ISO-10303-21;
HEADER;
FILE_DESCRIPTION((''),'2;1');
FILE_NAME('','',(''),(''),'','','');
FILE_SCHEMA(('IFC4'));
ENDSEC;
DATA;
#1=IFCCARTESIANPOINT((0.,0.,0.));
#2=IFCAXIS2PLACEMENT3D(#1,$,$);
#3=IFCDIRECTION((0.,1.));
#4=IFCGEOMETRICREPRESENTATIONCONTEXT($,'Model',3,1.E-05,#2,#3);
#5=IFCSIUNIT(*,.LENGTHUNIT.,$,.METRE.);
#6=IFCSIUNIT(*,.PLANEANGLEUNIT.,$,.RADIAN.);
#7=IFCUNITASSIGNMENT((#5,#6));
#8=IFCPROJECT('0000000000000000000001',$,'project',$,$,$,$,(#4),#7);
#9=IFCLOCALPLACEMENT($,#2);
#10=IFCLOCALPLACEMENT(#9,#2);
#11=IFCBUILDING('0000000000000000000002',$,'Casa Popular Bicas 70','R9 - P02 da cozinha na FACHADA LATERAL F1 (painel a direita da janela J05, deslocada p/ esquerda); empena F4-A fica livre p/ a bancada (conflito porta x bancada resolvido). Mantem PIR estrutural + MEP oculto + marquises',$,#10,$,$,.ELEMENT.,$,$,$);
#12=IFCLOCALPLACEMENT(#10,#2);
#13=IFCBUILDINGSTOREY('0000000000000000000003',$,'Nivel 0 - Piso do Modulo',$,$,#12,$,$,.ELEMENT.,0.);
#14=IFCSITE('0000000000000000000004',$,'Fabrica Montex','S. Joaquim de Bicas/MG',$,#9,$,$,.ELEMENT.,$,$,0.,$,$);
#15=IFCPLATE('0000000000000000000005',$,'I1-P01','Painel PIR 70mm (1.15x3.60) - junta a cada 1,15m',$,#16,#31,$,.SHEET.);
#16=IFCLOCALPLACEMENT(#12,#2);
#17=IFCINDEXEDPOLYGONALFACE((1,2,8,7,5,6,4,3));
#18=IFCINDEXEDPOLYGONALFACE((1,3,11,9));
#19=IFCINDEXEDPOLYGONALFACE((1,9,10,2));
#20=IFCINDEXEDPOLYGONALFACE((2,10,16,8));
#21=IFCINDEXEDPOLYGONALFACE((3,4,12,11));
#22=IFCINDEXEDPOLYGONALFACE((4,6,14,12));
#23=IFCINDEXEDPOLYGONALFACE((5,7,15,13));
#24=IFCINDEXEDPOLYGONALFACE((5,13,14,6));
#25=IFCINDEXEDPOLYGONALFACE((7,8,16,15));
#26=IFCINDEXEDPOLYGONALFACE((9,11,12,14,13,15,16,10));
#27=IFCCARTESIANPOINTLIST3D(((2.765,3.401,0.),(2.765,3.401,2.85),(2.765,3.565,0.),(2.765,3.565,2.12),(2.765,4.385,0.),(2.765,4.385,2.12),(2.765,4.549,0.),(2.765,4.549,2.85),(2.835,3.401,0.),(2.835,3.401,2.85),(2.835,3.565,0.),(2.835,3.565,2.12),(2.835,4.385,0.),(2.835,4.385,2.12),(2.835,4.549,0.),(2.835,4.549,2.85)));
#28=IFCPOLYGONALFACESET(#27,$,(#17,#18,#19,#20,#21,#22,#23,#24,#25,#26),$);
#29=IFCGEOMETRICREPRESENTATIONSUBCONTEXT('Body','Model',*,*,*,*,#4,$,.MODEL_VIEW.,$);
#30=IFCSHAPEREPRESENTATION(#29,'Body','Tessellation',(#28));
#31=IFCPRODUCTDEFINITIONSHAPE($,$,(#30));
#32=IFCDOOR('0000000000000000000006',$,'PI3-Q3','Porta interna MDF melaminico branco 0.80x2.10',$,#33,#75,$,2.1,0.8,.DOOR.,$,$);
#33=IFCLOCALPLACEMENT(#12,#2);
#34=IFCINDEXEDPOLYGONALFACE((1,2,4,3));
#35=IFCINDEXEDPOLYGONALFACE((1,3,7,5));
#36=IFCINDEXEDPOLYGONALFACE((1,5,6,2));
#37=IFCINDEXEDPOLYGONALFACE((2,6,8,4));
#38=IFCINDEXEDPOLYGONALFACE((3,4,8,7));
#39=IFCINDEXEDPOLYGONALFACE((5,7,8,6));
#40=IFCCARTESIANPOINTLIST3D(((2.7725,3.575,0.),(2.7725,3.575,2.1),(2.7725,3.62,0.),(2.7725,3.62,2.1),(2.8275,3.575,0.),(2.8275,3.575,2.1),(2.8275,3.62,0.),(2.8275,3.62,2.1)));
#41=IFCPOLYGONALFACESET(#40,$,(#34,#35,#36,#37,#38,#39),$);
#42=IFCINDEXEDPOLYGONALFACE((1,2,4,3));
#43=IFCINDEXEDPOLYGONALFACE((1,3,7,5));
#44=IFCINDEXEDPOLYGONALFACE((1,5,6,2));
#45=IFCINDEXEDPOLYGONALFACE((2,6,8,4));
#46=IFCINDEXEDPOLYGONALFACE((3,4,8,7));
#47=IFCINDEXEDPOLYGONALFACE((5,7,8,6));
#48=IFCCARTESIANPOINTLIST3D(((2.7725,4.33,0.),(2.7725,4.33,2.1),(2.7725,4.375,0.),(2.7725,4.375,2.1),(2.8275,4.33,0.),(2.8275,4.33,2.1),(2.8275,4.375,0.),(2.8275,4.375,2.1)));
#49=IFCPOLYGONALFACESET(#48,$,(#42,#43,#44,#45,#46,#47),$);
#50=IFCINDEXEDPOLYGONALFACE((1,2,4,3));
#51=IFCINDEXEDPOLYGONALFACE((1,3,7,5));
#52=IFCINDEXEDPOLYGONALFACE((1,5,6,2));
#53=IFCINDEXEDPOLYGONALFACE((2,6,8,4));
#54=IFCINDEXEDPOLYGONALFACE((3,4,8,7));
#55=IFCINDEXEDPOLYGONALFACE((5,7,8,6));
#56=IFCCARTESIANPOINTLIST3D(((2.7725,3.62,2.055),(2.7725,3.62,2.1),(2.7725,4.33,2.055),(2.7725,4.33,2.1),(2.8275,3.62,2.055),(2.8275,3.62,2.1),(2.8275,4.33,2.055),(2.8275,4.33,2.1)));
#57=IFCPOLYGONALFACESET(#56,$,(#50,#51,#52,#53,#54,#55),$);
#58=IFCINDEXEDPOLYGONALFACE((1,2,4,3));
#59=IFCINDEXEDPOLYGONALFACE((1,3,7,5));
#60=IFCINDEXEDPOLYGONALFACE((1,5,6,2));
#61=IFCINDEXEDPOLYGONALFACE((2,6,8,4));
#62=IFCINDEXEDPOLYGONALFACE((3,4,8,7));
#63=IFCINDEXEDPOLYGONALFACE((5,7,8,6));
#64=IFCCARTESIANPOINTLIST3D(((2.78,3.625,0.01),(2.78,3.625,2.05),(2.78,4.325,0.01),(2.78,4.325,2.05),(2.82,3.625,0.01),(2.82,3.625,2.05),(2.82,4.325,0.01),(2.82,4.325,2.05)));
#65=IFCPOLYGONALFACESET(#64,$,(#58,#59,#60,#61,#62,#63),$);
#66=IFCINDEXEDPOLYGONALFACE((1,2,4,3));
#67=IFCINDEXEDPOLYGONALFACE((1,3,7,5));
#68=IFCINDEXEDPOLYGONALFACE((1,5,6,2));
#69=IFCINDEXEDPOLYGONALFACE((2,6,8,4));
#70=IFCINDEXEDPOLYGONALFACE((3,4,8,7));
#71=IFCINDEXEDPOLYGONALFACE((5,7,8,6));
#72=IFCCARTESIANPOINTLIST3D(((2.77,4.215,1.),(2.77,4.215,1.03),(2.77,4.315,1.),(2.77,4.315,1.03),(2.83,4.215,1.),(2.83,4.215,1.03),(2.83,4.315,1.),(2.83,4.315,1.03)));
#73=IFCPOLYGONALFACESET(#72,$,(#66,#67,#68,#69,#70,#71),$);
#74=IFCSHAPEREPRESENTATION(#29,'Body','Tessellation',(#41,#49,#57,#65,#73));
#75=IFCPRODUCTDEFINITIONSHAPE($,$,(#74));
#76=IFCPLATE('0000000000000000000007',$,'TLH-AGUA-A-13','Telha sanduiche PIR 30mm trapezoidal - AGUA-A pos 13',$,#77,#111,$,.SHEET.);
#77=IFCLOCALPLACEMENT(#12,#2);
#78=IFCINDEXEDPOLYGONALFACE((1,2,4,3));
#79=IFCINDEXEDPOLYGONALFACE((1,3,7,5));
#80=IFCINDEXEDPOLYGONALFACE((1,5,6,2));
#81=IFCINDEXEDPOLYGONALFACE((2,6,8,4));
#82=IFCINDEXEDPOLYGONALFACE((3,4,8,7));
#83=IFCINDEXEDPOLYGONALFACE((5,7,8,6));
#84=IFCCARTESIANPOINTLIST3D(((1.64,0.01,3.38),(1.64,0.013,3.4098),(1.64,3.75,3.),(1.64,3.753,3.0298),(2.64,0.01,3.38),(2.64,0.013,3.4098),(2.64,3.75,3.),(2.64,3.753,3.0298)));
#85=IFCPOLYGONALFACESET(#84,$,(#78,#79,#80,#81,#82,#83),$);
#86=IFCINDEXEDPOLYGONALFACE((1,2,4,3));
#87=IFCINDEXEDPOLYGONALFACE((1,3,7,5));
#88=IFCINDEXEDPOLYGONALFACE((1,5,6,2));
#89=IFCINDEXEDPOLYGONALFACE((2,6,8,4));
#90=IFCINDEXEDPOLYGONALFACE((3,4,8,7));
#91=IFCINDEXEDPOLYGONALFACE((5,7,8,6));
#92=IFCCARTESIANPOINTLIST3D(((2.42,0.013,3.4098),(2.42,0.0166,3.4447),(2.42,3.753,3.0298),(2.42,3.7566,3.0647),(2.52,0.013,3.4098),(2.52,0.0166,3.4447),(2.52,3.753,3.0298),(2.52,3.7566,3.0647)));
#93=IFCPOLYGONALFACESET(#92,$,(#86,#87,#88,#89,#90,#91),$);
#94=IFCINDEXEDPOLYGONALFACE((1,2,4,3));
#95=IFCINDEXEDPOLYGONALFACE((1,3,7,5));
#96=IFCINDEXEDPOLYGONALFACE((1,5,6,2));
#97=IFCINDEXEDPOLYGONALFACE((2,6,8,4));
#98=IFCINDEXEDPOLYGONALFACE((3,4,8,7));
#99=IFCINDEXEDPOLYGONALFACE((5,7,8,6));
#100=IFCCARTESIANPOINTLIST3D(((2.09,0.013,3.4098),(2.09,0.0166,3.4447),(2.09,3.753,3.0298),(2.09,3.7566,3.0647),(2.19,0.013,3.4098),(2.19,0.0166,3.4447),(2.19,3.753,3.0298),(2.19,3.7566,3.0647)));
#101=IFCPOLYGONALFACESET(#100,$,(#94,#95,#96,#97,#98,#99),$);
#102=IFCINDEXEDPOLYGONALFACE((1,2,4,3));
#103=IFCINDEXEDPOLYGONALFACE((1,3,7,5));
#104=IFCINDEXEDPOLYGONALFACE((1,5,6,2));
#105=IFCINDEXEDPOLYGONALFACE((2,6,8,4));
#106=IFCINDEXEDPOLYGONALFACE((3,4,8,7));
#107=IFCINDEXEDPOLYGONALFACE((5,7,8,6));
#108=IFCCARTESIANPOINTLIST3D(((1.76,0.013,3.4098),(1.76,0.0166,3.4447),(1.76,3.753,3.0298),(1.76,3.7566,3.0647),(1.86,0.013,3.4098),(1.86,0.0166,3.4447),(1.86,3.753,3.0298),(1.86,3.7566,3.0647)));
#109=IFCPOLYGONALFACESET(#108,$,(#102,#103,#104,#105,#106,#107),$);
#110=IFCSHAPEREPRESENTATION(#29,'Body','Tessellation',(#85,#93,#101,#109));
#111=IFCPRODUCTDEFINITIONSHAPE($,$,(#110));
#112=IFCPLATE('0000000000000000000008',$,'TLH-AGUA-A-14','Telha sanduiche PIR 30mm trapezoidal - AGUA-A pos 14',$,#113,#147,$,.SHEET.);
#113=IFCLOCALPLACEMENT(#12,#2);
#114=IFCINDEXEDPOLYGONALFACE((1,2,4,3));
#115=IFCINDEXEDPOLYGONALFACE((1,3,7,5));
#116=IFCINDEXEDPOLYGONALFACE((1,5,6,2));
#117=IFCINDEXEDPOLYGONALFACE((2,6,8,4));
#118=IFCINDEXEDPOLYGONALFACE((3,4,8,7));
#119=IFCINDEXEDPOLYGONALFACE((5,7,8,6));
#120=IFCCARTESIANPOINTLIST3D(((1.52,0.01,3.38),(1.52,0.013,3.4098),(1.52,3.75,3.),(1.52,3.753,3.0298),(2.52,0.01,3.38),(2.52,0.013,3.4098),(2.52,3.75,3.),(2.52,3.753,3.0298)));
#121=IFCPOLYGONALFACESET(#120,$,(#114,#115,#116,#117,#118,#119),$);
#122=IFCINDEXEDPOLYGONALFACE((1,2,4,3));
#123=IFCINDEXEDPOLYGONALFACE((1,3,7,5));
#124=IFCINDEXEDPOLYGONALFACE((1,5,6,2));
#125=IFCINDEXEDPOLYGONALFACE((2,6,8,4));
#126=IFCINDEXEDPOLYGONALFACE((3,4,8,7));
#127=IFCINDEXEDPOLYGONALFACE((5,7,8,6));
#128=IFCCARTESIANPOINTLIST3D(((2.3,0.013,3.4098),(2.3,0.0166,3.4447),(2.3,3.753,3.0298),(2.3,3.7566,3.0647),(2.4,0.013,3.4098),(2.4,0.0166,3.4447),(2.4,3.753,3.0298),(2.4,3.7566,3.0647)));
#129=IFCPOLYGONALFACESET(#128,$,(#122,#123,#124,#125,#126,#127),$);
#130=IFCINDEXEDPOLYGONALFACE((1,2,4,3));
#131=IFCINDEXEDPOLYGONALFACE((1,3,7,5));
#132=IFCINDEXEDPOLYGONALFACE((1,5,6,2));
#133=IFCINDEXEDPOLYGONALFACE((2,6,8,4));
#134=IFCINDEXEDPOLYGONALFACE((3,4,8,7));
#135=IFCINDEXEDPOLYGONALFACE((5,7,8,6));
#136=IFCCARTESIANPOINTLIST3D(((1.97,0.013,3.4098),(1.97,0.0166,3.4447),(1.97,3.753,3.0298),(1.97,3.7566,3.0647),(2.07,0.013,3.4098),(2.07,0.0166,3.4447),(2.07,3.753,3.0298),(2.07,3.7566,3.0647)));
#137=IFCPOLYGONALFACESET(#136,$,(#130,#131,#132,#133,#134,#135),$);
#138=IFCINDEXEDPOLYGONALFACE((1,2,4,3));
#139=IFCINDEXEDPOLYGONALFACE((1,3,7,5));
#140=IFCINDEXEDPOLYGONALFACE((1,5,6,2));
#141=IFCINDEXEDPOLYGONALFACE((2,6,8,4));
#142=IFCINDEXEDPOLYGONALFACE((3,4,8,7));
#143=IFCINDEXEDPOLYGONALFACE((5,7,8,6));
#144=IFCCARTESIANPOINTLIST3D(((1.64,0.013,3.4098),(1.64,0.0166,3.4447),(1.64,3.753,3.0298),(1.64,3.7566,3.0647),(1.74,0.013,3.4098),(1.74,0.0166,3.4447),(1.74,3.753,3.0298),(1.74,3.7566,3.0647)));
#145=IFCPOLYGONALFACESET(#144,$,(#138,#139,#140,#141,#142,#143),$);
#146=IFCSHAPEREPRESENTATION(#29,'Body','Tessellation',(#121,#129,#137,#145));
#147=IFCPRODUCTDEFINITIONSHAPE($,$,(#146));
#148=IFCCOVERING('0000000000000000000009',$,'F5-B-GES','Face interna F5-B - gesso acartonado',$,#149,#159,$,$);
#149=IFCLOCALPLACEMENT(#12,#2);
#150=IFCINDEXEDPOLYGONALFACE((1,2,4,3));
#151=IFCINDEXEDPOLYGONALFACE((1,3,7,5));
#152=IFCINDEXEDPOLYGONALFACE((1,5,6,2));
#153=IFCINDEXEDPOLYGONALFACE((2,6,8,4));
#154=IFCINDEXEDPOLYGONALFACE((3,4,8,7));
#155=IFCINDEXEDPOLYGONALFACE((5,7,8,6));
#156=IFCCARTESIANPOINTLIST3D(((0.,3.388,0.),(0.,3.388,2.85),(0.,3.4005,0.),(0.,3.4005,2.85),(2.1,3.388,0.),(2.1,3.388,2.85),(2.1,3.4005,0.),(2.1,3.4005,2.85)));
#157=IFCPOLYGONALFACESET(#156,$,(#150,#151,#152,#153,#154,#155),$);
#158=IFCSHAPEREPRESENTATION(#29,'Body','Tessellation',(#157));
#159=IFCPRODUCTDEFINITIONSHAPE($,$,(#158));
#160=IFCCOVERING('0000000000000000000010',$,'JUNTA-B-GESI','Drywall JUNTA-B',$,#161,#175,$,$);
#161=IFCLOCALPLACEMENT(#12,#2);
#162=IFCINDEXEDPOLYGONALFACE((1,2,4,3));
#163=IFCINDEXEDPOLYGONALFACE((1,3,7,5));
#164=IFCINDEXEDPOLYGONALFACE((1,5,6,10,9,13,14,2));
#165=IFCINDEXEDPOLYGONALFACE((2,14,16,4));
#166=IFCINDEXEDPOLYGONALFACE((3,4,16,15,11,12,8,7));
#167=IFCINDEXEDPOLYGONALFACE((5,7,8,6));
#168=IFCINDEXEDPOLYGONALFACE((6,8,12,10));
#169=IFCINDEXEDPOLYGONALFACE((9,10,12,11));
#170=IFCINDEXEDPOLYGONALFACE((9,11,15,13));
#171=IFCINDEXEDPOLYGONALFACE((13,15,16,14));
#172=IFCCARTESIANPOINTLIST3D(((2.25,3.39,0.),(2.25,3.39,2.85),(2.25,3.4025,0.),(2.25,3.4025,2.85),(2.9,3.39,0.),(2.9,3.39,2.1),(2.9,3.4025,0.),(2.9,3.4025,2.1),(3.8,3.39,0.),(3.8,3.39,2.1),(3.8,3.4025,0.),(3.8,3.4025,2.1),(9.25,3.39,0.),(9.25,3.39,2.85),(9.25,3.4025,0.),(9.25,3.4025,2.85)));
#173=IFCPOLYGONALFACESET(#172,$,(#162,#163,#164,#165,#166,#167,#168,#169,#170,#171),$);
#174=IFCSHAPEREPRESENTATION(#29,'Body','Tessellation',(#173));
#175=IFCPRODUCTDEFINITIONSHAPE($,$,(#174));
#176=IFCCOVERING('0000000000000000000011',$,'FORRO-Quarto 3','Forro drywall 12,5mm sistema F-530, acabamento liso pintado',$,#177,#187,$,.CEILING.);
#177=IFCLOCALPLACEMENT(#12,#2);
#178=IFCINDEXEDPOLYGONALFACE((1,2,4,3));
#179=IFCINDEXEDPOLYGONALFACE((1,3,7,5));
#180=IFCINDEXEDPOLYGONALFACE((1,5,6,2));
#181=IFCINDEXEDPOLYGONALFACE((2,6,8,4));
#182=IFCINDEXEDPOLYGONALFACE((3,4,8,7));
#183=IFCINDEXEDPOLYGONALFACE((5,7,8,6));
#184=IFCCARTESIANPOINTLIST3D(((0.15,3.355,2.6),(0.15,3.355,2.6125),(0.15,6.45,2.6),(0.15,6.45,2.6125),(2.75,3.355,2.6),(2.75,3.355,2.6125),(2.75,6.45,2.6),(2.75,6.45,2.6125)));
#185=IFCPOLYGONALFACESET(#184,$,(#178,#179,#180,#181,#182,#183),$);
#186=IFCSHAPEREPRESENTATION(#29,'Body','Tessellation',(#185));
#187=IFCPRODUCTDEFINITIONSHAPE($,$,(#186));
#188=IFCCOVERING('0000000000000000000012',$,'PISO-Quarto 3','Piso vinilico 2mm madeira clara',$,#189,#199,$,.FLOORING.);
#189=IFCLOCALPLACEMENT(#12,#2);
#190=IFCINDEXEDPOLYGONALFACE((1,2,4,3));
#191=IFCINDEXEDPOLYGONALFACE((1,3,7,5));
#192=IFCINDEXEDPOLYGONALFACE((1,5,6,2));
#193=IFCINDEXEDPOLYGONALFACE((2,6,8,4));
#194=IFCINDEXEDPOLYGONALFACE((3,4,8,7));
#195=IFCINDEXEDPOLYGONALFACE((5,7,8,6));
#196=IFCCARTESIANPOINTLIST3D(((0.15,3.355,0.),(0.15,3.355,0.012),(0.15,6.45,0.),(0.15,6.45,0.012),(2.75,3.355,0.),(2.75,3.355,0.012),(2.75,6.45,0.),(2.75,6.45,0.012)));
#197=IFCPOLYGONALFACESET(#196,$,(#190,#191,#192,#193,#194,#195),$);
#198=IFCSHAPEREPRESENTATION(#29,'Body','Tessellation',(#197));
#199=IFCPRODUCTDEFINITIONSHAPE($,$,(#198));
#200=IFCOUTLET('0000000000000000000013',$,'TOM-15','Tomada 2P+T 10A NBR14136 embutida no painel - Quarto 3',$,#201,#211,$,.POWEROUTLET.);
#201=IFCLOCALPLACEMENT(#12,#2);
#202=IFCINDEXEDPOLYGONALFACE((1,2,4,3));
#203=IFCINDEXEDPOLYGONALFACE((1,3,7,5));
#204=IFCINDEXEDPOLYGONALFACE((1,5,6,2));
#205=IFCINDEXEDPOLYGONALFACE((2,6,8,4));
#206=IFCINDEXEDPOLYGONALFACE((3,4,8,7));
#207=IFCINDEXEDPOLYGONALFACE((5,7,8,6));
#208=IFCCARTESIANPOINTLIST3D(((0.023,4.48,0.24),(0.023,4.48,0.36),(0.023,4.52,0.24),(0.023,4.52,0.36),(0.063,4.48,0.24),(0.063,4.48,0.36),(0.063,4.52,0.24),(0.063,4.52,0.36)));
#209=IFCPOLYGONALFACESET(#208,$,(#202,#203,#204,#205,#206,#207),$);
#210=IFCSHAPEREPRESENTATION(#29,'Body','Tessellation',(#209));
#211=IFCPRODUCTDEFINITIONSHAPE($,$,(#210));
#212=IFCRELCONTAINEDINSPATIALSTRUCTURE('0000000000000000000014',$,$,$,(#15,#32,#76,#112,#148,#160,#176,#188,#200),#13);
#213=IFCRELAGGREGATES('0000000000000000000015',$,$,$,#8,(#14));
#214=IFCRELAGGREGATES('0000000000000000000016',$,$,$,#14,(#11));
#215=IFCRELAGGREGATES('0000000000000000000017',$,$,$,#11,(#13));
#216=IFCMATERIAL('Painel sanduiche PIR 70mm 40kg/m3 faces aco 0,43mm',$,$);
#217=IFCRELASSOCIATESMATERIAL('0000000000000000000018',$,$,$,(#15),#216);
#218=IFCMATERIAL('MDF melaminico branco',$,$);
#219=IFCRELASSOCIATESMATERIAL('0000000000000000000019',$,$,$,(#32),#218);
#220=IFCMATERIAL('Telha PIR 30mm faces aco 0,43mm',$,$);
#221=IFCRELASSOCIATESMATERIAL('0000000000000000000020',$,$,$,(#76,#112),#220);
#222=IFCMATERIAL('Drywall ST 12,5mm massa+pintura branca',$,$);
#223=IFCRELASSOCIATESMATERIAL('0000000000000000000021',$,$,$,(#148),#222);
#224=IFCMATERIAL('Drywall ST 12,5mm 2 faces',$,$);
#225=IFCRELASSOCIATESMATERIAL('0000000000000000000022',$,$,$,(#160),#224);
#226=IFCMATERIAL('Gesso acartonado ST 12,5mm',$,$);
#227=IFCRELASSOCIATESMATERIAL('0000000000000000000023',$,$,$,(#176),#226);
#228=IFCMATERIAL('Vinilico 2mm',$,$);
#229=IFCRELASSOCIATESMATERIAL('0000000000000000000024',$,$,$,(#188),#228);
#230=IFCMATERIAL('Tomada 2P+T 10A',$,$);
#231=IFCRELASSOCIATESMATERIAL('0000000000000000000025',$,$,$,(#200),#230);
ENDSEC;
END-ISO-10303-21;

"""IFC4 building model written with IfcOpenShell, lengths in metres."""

from ifc_helpers import new_model, si_unit, direction, frame, frame_2d, origin, origin_2d, place, context, subcontext, project, spatial, rectangle, extrude, material, element, fill, save


model = new_model("IFC4")

# Units and contexts
model_context = context("Model", 3, precision=1e-05, world=origin(), true_north=direction((0.0, 1.0)))
body_context = subcontext(model_context, "Body", "Model", "MODEL_VIEW")
ifc_project = project(units=[si_unit("LENGTHUNIT", "METRE"), si_unit("PLANEANGLEUNIT", "RADIAN")], contexts=[model_context])

# Site, building, storey
site_placement = place(None, origin())
site = spatial("IfcSite", under=ifc_project, at=site_placement, Name="Fabrica Montex", Description="S. Joaquim de Bicas/MG", CompositionType="ELEMENT", RefElevation=0.0)
building_placement = place(site_placement, origin())
building = spatial("IfcBuilding", under=site, at=building_placement, Name="Casa Popular Bicas 70", Description="R9 - P02 da cozinha na FACHADA LATERAL F1 (painel a direita da janela J05, deslocada p/ esquerda); empena F4-A fica livre p/ a bancada (conflito porta x bancada resolvido). Mantem PIR estrutural + MEP oculto + marquises", CompositionType="ELEMENT")
storey_placement = place(building_placement, origin())
storey = spatial("IfcBuildingStorey", under=building, at=storey_placement, Name="Nivel 0 - Piso do Modulo", CompositionType="ELEMENT", Elevation=0.0)

# Shared definitions
ifc_material_1 = material(Name="Painel sanduiche PIR 70mm 40kg/m3 faces aco 0,43mm")

# Plate, opening, door
plate_1_placement = place(storey_placement, frame((2.8, 3.401, 0.0), x_axis=(0.0, 1.0, 0.0)))
plate_1 = element("IfcPlate", 1, at=plate_1_placement, inside=storey, material=ifc_material_1, Name="I1-P01", Description="Painel PIR 70mm (1.15x3.60) - junta a cada 1,15m", PredefinedType="SHEET", context=body_context, shape_type="SweptSolid", body=[
    extrude(rectangle(XDim=1.148, YDim=0.07, at=frame_2d((0.574, 0.0))), origin(), (0.0, 0.0, 1.0), 2.85),
])
opening_1_placement = place(storey_placement, frame((2.8, 3.575, 0.0), x_axis=(0.0, 1.0, 0.0)))
opening_1 = element("IfcOpeningElement", 2, at=opening_1_placement, cuts=plate_1, PredefinedType="OPENING", context=body_context, shape_type="SweptSolid", body=[
    extrude(rectangle(XDim=0.82, YDim=0.3, at=frame_2d((0.4, 0.0))), origin(), (0.0, 0.0, 1.0), 2.12),
])
ifc_material_2 = material(Name="MDF melaminico branco")
door_placement = place(storey_placement, frame((2.8, 3.575, 0.0), x_axis=(0.0, 1.0, 0.0)))
door = element("IfcDoor", 3, at=door_placement, inside=storey, material=ifc_material_2, Name="PI3-Q3", Description="Porta interna MDF melaminico branco 0.80x2.10", OverallHeight=2.1, OverallWidth=0.8, PredefinedType="DOOR", context=body_context, shape_type="SweptSolid", body=[
    extrude(rectangle(XDim=0.045, YDim=0.055, at=frame_2d((0.0225, 0.0))), origin(), (0.0, 0.0, 1.0), 2.1),
    extrude(rectangle(XDim=0.045, YDim=0.055, at=frame_2d((0.7775, 0.0))), origin(), (0.0, 0.0, 1.0), 2.1),
    extrude(rectangle(XDim=0.71, YDim=0.055, at=frame_2d((0.4, 0.0))), frame((0.0, 0.0, 2.055)), (0.0, 0.0, 1.0), 0.045),
    extrude(rectangle(XDim=0.7, YDim=0.04, at=frame_2d((0.4, 0.0))), frame((0.0, 0.0, 0.01)), (0.0, 0.0, 1.0), 2.04),
    extrude(rectangle(XDim=0.1, YDim=0.06, at=frame_2d((0.69, 0.0))), frame((0.0, 0.0, 1.0)), (0.0, 0.0, 1.0), 0.03),
])
fill(opening_1, door)

# Plates
ifc_material_3 = material(Name="Telha PIR 30mm faces aco 0,43mm")
for number, where, z_axis, x_axis, name, description in (
    (4, (2.64, 3.75, 3.0), (0.0, 0.101084, 0.994878), (-1.0, 0.0, 0.0), "TLH-AGUA-A-13", "Telha sanduiche PIR 30mm trapezoidal - AGUA-A pos 13"),
    (5, (2.52, 3.75, 3.0), (0.0, 0.101084, 0.994878), (-1.0, 0.0, 0.0), "TLH-AGUA-A-14", "Telha sanduiche PIR 30mm trapezoidal - AGUA-A pos 14"),
):
    element("IfcPlate", number, at=place(None, frame(where, z_axis=z_axis, x_axis=x_axis)), inside=storey, material=ifc_material_3, Name=name, Description=description, PredefinedType="SHEET", context=body_context, shape_type="SweptSolid", body=[
        extrude(rectangle(XDim=1.0, YDim=3.7593, at=frame_2d((0.5, 1.8796))), origin(), (0.0, 0.0, 1.0), 0.03),
        extrude(rectangle(XDim=0.1, YDim=3.7593, at=frame_2d((0.17, 1.8796))), frame((0.0, 0.0, 0.03)), (0.0, 0.0, 1.0), 0.035),
        extrude(rectangle(XDim=0.1, YDim=3.7593, at=frame_2d((0.5, 1.8796))), frame((0.0, 0.0, 0.03)), (0.0, 0.0, 1.0), 0.035),
        extrude(rectangle(XDim=0.1, YDim=3.7593, at=frame_2d((0.83, 1.8796))), frame((0.0, 0.0, 0.03)), (0.0, 0.0, 1.0), 0.035),
    ])

# Covering
ifc_material_4 = material(Name="Drywall ST 12,5mm massa+pintura branca")
covering_1_placement = place(storey_placement, frame((0.0, 3.3942, 0.0), x_axis=(1.0, 0.0, 0.0)))
element("IfcCovering", 6, at=covering_1_placement, inside=storey, material=ifc_material_4, Name="F5-B-GES", Description="Face interna F5-B - gesso acartonado", context=body_context, shape_type="SweptSolid", body=[
    extrude(rectangle(XDim=2.1, YDim=0.0125, at=frame_2d((1.05, 0.0))), origin(), (0.0, 0.0, 1.0), 2.85),
])

# Covering, opening
ifc_material_5 = material(Name="Drywall ST 12,5mm 2 faces")
covering_2_placement = place(storey_placement, frame((2.25, 3.3962, 0.0), x_axis=(1.0, 0.0, 0.0)))
covering_2 = element("IfcCovering", 7, at=covering_2_placement, inside=storey, material=ifc_material_5, Name="JUNTA-B-GESI", Description="Drywall JUNTA-B", context=body_context, shape_type="SweptSolid", body=[
    extrude(rectangle(XDim=7.0, YDim=0.0125, at=frame_2d((3.5, 0.0))), origin(), (0.0, 0.0, 1.0), 2.85),
])
opening_2_placement = place(storey_placement, frame((3.35, 3.3962, 0.0)))
element("IfcOpeningElement", 8, at=opening_2_placement, cuts=covering_2, PredefinedType="OPENING", context=body_context, shape_type="SweptSolid", body=[
    extrude(rectangle(XDim=0.9, YDim=0.0425, at=origin_2d()), origin(), (0.0, 0.0, 1.0), 2.1),
])

# Coverings
ifc_material_6 = material(Name="Gesso acartonado ST 12,5mm")
covering_3_placement = place(storey_placement, frame((0.15, 3.355, 2.6)))
element("IfcCovering", 9, at=covering_3_placement, inside=storey, material=ifc_material_6, Name="FORRO-Quarto 3", Description="Forro drywall 12,5mm sistema F-530, acabamento liso pintado", PredefinedType="CEILING", context=body_context, shape_type="SweptSolid", body=[
    extrude(rectangle(XDim=2.6, YDim=3.095, at=frame_2d((1.3, 1.5475))), origin(), (0.0, 0.0, 1.0), 0.0125),
])
ifc_material_7 = material(Name="Vinilico 2mm")
covering_4_placement = place(storey_placement, frame((0.15, 3.355, 0.0)))
element("IfcCovering", 10, at=covering_4_placement, inside=storey, material=ifc_material_7, Name="PISO-Quarto 3", Description="Piso vinilico 2mm madeira clara", PredefinedType="FLOORING", context=body_context, shape_type="SweptSolid", body=[
    extrude(rectangle(XDim=2.6, YDim=3.095, at=frame_2d((1.3, 1.5475))), origin(), (0.0, 0.0, 1.0), 0.012),
])

# Outlet
ifc_material_8 = material(Name="Tomada 2P+T 10A")
outlet_placement = place(storey_placement, frame((0.023, 4.48, 0.24)))
element("IfcOutlet", 11, at=outlet_placement, inside=storey, material=ifc_material_8, Name="TOM-15", Description="Tomada 2P+T 10A NBR14136 embutida no painel - Quarto 3", PredefinedType="POWEROUTLET", context=body_context, shape_type="SweptSolid", body=[
    extrude(rectangle(XDim=0.04, YDim=0.04, at=frame_2d((0.02, 0.02))), origin(), (0.0, 0.0, 1.0), 0.12),
])

save(model, "model.ifc")
